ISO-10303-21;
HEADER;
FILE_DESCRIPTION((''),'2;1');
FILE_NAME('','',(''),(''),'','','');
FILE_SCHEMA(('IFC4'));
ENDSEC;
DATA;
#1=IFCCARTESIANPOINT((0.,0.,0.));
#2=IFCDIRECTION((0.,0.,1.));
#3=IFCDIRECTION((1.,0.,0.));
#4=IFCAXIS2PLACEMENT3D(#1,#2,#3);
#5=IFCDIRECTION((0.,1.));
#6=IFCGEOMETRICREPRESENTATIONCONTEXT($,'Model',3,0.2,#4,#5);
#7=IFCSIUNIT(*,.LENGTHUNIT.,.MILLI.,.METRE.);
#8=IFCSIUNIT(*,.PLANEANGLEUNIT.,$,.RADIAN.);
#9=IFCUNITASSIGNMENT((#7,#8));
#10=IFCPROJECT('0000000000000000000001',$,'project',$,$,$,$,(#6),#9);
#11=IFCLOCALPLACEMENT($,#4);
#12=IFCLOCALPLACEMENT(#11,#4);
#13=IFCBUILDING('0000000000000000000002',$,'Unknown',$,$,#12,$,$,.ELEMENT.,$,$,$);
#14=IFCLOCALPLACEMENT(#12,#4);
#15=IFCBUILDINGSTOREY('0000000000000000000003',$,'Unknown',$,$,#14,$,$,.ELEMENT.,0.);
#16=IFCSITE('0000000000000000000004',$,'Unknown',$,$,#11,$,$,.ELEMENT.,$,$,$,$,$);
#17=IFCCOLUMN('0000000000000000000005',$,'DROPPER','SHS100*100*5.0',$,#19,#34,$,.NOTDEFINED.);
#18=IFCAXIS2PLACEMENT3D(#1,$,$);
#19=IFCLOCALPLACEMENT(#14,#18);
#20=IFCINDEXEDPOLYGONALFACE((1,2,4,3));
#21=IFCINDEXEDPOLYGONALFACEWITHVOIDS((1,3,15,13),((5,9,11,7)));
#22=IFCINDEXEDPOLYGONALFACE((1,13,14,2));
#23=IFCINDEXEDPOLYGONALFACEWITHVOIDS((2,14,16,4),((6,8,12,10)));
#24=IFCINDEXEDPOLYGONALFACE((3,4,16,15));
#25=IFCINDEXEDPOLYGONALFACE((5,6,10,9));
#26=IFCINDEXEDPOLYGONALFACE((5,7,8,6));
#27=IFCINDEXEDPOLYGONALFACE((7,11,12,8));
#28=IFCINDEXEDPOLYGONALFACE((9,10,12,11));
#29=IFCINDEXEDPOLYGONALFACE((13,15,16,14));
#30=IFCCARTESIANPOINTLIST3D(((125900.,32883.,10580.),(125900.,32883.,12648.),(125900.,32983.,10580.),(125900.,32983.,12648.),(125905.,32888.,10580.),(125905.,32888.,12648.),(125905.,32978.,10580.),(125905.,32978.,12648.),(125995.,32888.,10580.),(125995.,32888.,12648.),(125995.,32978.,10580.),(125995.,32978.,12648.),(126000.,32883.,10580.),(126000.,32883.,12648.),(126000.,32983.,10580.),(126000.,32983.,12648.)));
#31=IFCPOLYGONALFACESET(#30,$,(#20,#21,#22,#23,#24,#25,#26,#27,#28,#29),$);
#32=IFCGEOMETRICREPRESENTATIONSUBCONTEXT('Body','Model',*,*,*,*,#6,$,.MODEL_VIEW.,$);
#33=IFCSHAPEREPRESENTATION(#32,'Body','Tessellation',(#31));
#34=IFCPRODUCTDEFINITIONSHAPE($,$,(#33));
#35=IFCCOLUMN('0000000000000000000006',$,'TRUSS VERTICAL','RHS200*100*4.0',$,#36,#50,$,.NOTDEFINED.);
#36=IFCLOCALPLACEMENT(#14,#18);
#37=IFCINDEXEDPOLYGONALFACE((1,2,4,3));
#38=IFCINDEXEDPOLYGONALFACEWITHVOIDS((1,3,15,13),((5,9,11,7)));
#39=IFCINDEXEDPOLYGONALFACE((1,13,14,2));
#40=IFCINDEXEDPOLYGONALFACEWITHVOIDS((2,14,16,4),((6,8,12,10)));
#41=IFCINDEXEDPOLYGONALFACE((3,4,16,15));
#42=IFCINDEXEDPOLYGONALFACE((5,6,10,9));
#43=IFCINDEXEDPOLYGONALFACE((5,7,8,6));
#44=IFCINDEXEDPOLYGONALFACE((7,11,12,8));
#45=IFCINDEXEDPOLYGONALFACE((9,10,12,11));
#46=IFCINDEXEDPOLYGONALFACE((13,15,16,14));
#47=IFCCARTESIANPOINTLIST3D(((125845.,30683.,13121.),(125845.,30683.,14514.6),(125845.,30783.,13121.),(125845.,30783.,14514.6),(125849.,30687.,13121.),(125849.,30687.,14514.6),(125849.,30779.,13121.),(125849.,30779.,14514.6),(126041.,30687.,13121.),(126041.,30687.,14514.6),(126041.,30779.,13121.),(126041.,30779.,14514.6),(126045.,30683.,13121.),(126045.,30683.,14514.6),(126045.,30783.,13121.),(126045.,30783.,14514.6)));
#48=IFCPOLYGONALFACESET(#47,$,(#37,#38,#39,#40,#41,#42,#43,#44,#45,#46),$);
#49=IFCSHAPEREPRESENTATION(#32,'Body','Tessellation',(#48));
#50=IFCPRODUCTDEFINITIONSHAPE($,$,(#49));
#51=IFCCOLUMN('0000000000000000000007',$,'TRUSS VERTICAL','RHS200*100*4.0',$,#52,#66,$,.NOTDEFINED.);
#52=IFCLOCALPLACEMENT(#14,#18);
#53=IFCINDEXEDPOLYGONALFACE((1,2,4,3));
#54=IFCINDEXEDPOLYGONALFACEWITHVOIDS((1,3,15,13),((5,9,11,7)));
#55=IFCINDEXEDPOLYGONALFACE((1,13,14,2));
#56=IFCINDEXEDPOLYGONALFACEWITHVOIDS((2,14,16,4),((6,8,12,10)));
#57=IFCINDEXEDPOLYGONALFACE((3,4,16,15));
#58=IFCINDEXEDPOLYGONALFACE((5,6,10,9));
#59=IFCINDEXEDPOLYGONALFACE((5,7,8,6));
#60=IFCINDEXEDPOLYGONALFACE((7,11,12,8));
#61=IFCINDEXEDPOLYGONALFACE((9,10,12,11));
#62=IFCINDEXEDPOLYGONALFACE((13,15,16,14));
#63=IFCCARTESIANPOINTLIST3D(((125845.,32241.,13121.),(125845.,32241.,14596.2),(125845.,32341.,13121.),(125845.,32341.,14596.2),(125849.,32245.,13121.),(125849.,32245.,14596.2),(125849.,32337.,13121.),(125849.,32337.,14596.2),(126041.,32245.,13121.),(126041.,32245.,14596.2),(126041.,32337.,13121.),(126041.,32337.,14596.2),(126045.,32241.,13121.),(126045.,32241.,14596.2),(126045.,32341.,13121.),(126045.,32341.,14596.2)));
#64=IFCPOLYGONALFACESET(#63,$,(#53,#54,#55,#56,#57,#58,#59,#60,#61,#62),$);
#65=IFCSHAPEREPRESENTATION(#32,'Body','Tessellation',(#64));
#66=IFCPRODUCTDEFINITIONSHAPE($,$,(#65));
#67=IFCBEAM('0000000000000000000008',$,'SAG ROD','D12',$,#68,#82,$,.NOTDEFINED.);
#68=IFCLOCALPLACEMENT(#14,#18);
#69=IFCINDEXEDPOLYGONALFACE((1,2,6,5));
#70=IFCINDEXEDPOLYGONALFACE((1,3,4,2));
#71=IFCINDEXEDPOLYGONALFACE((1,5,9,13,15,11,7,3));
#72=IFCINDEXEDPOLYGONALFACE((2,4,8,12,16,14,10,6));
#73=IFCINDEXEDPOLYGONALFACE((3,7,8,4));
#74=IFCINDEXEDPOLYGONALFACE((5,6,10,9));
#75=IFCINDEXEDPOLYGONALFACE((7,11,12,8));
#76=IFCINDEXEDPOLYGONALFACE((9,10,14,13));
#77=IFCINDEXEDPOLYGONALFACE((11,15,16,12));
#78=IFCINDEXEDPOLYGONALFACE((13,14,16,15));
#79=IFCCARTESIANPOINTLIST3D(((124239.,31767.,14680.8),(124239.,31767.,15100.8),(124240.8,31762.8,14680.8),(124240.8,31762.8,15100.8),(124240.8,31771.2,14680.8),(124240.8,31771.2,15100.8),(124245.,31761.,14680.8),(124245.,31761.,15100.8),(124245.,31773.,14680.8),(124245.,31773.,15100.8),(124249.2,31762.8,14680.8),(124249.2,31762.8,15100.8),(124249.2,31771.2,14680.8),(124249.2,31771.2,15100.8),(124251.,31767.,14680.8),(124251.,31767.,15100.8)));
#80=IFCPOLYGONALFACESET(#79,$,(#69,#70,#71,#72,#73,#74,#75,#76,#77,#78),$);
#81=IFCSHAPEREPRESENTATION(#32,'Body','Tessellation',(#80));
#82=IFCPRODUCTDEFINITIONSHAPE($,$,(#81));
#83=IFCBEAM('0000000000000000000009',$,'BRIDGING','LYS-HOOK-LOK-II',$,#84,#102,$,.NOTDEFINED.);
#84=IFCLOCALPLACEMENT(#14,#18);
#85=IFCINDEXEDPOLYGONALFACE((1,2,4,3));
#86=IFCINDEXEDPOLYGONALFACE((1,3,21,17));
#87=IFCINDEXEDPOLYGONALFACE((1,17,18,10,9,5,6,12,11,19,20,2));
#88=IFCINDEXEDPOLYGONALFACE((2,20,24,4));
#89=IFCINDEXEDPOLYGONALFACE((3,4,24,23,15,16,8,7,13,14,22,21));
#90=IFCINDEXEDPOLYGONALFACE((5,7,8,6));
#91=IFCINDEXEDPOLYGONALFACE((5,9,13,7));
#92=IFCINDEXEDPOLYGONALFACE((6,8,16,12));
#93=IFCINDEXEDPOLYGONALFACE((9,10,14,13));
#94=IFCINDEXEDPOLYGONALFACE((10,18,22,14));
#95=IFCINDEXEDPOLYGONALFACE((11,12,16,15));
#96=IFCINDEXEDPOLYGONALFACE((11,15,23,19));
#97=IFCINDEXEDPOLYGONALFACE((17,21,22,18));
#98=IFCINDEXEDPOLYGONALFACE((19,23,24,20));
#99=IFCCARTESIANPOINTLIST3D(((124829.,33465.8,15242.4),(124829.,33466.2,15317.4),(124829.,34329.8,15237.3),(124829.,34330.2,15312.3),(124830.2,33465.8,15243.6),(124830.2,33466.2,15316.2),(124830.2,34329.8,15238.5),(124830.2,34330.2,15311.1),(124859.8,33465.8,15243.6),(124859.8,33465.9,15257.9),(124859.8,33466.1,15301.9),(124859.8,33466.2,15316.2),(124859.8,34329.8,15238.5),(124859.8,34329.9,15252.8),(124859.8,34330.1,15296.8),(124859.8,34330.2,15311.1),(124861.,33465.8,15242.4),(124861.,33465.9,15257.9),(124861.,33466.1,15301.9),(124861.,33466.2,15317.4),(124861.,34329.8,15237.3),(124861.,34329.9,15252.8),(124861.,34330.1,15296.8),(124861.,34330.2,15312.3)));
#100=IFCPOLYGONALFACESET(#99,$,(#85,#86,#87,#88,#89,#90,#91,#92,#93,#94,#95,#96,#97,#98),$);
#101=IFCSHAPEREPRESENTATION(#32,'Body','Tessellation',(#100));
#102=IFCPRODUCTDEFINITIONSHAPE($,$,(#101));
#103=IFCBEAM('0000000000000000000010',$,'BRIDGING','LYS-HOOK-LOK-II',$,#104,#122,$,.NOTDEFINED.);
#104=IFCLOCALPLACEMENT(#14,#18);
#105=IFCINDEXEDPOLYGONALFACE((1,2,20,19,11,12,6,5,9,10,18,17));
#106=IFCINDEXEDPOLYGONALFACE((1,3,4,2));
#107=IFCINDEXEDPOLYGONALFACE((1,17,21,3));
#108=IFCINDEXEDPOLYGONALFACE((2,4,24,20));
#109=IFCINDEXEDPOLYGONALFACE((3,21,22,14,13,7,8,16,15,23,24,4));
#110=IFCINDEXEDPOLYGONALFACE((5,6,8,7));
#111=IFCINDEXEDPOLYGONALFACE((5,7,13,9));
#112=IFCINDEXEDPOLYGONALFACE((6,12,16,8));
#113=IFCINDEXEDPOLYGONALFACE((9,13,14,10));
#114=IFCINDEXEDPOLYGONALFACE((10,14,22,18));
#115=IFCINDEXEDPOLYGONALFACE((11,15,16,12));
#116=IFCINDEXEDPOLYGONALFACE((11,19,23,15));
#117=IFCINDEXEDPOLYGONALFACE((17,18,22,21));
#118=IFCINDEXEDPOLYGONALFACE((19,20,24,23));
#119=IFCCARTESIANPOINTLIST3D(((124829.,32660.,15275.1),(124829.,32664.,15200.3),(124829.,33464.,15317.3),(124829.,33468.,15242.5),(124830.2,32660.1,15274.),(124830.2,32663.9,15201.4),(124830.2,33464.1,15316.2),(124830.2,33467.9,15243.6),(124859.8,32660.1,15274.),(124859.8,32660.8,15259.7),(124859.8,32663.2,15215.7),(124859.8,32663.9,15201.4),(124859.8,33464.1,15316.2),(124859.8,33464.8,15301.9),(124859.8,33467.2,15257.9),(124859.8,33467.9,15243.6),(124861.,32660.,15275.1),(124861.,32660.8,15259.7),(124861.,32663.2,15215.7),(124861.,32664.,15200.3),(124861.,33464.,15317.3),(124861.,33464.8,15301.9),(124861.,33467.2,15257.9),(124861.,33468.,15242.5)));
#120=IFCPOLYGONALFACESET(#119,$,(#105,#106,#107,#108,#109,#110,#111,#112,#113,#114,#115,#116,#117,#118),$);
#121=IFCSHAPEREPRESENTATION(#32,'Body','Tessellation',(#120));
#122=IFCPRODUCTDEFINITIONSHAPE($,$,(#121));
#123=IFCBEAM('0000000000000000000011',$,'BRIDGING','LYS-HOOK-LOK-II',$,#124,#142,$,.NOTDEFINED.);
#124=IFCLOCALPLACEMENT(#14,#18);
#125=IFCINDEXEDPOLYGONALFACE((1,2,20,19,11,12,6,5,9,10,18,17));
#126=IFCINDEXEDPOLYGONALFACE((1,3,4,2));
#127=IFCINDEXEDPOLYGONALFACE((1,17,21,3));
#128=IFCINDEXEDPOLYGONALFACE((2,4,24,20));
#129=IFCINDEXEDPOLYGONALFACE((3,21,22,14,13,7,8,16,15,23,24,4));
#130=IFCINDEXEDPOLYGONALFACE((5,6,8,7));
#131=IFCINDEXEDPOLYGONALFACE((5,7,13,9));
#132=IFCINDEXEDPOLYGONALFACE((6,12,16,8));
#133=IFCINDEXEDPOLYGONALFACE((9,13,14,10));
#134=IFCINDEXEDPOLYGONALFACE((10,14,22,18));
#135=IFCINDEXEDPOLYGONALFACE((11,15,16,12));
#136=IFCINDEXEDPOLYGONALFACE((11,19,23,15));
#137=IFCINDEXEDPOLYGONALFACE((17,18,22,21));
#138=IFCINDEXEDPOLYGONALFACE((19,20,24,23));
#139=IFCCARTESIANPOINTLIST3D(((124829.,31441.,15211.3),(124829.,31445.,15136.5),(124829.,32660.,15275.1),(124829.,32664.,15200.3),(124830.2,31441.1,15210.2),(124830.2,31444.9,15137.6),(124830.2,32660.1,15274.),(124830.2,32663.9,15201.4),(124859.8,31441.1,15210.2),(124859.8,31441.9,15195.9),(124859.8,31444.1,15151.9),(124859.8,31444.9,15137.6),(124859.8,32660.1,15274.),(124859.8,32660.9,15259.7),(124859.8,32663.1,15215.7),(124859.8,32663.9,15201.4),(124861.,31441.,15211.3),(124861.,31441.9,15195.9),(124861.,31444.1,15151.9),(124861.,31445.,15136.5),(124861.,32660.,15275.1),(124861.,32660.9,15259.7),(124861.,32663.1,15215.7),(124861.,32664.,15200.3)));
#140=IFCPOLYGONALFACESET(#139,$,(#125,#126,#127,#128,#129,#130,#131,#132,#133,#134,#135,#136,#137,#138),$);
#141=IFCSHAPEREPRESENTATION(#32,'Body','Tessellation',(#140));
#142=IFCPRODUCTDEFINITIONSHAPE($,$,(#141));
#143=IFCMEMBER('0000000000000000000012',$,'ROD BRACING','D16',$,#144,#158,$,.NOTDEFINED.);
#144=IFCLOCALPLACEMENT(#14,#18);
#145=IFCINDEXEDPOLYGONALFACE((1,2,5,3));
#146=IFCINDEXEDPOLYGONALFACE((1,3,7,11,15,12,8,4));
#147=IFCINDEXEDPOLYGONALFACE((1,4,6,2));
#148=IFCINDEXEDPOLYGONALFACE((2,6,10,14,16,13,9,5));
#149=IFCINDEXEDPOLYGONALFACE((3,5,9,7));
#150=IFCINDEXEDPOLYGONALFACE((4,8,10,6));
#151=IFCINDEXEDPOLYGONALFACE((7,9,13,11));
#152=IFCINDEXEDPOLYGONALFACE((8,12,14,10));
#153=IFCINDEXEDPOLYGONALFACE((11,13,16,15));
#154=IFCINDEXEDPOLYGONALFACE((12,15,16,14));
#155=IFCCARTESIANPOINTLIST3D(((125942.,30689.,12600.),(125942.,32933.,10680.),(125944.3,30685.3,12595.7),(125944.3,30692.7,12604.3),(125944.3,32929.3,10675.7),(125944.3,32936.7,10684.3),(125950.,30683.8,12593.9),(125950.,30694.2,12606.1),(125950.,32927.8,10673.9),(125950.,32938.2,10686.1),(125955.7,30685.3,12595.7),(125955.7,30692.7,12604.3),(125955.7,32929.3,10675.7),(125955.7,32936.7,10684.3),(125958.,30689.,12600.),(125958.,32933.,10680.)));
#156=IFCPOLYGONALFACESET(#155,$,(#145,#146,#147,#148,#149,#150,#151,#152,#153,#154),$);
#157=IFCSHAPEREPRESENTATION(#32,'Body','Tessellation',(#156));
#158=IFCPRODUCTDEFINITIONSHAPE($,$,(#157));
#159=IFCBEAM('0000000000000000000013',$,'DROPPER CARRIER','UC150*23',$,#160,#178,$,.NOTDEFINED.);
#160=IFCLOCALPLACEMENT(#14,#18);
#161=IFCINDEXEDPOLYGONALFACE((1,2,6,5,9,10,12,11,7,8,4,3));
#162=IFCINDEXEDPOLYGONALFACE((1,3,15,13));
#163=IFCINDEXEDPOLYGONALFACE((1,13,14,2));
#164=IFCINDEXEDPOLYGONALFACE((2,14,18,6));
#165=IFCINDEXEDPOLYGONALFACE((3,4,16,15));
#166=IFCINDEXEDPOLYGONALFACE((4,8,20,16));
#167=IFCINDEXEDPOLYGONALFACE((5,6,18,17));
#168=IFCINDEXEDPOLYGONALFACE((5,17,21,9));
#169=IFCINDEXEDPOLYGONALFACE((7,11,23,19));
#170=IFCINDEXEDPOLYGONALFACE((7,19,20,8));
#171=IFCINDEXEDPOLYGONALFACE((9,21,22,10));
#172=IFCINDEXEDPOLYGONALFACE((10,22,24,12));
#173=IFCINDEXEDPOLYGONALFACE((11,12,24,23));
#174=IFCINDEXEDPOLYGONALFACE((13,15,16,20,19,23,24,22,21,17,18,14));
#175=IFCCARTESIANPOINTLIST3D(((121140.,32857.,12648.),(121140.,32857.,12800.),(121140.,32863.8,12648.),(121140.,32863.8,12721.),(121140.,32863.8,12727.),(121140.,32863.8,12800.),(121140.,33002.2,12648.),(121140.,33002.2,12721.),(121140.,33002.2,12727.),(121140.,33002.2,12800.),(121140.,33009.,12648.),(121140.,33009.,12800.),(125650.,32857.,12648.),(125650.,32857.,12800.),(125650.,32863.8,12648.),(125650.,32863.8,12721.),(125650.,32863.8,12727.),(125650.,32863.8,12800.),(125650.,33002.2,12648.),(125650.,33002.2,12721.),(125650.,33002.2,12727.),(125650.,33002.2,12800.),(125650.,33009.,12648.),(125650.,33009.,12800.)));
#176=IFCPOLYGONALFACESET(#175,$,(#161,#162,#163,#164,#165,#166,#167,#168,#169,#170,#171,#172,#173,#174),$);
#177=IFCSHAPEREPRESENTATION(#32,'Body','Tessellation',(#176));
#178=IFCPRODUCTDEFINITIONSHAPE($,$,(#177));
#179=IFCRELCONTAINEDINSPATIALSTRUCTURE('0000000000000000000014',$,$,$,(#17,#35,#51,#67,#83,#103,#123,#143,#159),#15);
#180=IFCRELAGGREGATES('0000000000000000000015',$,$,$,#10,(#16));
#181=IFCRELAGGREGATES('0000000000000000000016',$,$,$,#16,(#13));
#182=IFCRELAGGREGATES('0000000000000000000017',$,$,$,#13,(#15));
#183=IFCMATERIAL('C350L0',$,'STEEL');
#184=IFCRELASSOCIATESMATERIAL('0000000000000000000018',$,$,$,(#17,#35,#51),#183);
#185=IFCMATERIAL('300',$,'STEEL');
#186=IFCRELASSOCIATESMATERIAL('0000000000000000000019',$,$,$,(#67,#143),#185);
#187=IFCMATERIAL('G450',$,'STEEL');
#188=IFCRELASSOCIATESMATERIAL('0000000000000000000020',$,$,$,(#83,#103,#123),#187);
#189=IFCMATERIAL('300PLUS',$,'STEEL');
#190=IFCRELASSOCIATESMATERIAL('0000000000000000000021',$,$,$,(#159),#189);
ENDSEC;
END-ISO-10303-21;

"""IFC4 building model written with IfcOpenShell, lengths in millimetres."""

from ifc_helpers import new_model, si_unit, direction, frame, origin_with_axes, place, context, subcontext, project, spatial, line, indexed_curve, outline, extrude, material, element, save


model = new_model("IFC4")

# Units and contexts
model_context = context("Model", 3, precision=0.2, world=origin_with_axes(), true_north=direction((0.0, 1.0)))
body_context = subcontext(model_context, "Body", "Model", "MODEL_VIEW")
ifc_project = project(units=[si_unit("LENGTHUNIT", "METRE", prefix="MILLI"), si_unit("PLANEANGLEUNIT", "RADIAN")], contexts=[model_context])

# Site, building, storey
site_placement = place(None, origin_with_axes())
site = spatial("IfcSite", under=ifc_project, at=site_placement, Name="Unknown", CompositionType="ELEMENT")
building_placement = place(site_placement, origin_with_axes())
building = spatial("IfcBuilding", under=site, at=building_placement, Name="Unknown", CompositionType="ELEMENT")
storey_placement = place(building_placement, origin_with_axes())
storey = spatial("IfcBuildingStorey", under=building, at=storey_placement, Name="Unknown", CompositionType="ELEMENT", Elevation=0.0)

# Columns
ifc_material_1 = material(Name="C350L0", Category="STEEL")
column_1_placement = place(storey_placement, frame((125950.0, 32933.0, 10580.0), z_axis=(-1.0, 0.0, 0.0), x_axis=(0.0, 0.0, 1.0)))
element("IfcColumn", 1, at=column_1_placement, inside=storey, material=ifc_material_1, Name="DROPPER", Description="SHS100*100*5.0", PredefinedType="NOTDEFINED", context=body_context, shape_type="SolidModel", body=[
    extrude(outline(indexed_curve([(-50.0, -50.0), (50.0, -50.0), (50.0, 50.0), (-50.0, 50.0)], segments=[line(1, 2, 3, 4, 1)]), holes=[indexed_curve([(-45.0, -45.0), (-45.0, 45.0), (45.0, 45.0), (45.0, -45.0)], segments=[line(1, 2, 3, 4, 1)])]), frame((0.0, 0.0, 0.0), z_axis=(-1.0, 0.0, 0.0), x_axis=(0.0, 0.0, 1.0)), (0.0, 0.0, -1.0), 2068.0),
])
column_2_placement = place(storey_placement, frame((125945.0, 30733.0, 13121.0), z_axis=(0.0, -1.0, 0.0), x_axis=(0.0, 0.0, 1.0)))
element("IfcColumn", 2, at=column_2_placement, inside=storey, material=ifc_material_1, Name="TRUSS VERTICAL", Description="RHS200*100*4.0", PredefinedType="NOTDEFINED", context=body_context, shape_type="SolidModel", body=[
    extrude(outline(indexed_curve([(-50.0, -100.0), (50.0, -100.0), (50.0, 100.0), (-50.0, 100.0)], segments=[line(1, 2, 3, 4, 1)]), holes=[indexed_curve([(-46.0, -96.0), (-46.0, 96.0), (46.0, 96.0), (46.0, -96.0)], segments=[line(1, 2, 3, 4, 1)])]), frame((0.0, 0.0, 0.0), z_axis=(-1.0, 0.0, 0.0), x_axis=(0.0, 0.0, 1.0)), (0.0, 0.0, -1.0), 1393.6),
])
column_3_placement = place(storey_placement, frame((125945.0, 32291.0, 13121.0), z_axis=(0.0, -1.0, 0.0), x_axis=(0.0, 0.0, 1.0)))
element("IfcColumn", 3, at=column_3_placement, inside=storey, material=ifc_material_1, Name="TRUSS VERTICAL", Description="RHS200*100*4.0", PredefinedType="NOTDEFINED", context=body_context, shape_type="SolidModel", body=[
    extrude(outline(indexed_curve([(-50.0, -100.0), (50.0, -100.0), (50.0, 100.0), (-50.0, 100.0)], segments=[line(1, 2, 3, 4, 1)]), holes=[indexed_curve([(-46.0, -96.0), (-46.0, 96.0), (46.0, 96.0), (46.0, -96.0)], segments=[line(1, 2, 3, 4, 1)])]), frame((0.0, 0.0, 0.0), z_axis=(-1.0, 0.0, 0.0), x_axis=(0.0, 0.0, 1.0)), (0.0, 0.0, -1.0), 1475.2),
])

# Beams
ifc_material_2 = material(Name="300", Category="STEEL")
beam_1_placement = place(storey_placement, frame((124245.0, 31767.0, 15100.8), z_axis=(1.0, 0.0, 0.0), x_axis=(0.0, 0.0, -1.0)))
element("IfcBeam", 4, at=beam_1_placement, inside=storey, material=ifc_material_2, Name="SAG ROD", Description="D12", PredefinedType="NOTDEFINED", context=body_context, shape_type="SolidModel", body=[
    extrude(outline(indexed_curve([(6.0, 0.0), (4.2, 4.2), (0.0, 6.0), (-4.2, 4.2), (-6.0, 0.0), (-4.2, -4.2), (0.0, -6.0), (4.2, -4.2)], segments=[line(1, 2, 3, 4, 5, 6, 7, 8, 1)])), frame((0.0, 0.0, 0.0), z_axis=(-1.0, 0.0, 0.0), x_axis=(0.0, 0.0, 1.0)), (0.0, 0.0, -1.0), 420.0),
])
ifc_material_3 = material(Name="G450", Category="STEEL")
beam_2_placement = place(storey_placement, frame((124845.0, 33466.0, 15279.9), z_axis=(1.0, 0.0, 0.0), x_axis=(0.0, 0.999983, -0.005903)))
element("IfcBeam", 5, at=beam_2_placement, inside=storey, material=ifc_material_3, Name="BRIDGING", Description="LYS-HOOK-LOK-II", PredefinedType="NOTDEFINED", context=body_context, shape_type="SolidModel", body=[
    extrude(outline(indexed_curve([(16.0, -37.5), (16.0, -22.0), (14.8, -22.0), (14.8, -36.3), (-14.8, -36.3), (-14.8, 36.3), (14.8, 36.3), (14.8, 22.0), (16.0, 22.0), (16.0, 37.5), (-16.0, 37.5), (-16.0, -37.5)], segments=[line(1, 2, 3, 4, 5, 6, 7, 8, 9, 10, 11, 12, 1)])), frame((0.0, 0.0, 0.0), z_axis=(-1.0, 0.0, 0.0), x_axis=(0.0, 0.0, 1.0)), (0.0, 0.0, -1.0), 864.0),
])
beam_3_placement = place(storey_placement, frame((124845.0, 32662.0, 15237.7), z_axis=(1.0, 0.0, 0.0), x_axis=(0.0, 0.998625, 0.052415)))
element("IfcBeam", 6, at=beam_3_placement, inside=storey, material=ifc_material_3, Name="BRIDGING", Description="LYS-HOOK-LOK-II", PredefinedType="NOTDEFINED", context=body_context, shape_type="SolidModel", body=[
    extrude(outline(indexed_curve([(16.0, -37.5), (16.0, -22.0), (14.8, -22.0), (14.8, -36.3), (-14.8, -36.3), (-14.8, 36.3), (14.8, 36.3), (14.8, 22.0), (16.0, 22.0), (16.0, 37.5), (-16.0, 37.5), (-16.0, -37.5)], segments=[line(1, 2, 3, 4, 5, 6, 7, 8, 9, 10, 11, 12, 1)])), frame((0.0, 0.0, 0.0), z_axis=(-1.0, 0.0, 0.0), x_axis=(0.0, 0.0, 1.0)), (0.0, 0.0, -1.0), 805.1),
])
beam_4_placement = place(storey_placement, frame((124845.0, 31443.0, 15173.9), z_axis=(1.0, 0.0, 0.0), x_axis=(0.0, 0.998633, 0.052266)))
element("IfcBeam", 7, at=beam_4_placement, inside=storey, material=ifc_material_3, Name="BRIDGING", Description="LYS-HOOK-LOK-II", PredefinedType="NOTDEFINED", context=body_context, shape_type="SolidModel", body=[
    extrude(outline(indexed_curve([(16.0, -37.5), (16.0, -22.0), (14.8, -22.0), (14.8, -36.3), (-14.8, -36.3), (-14.8, 36.3), (14.8, 36.3), (14.8, 22.0), (16.0, 22.0), (16.0, 37.5), (-16.0, 37.5), (-16.0, -37.5)], segments=[line(1, 2, 3, 4, 5, 6, 7, 8, 9, 10, 11, 12, 1)])), frame((0.0, 0.0, 0.0), z_axis=(-1.0, 0.0, 0.0), x_axis=(0.0, 0.0, 1.0)), (0.0, 0.0, -1.0), 1220.7),
])

# Member
member_placement = place(storey_placement, frame((125950.0, 32933.0, 10680.0), z_axis=(0.0, 0.650122, 0.75983), x_axis=(0.0, -0.75983, 0.650122)))
element("IfcMember", 8, at=member_placement, inside=storey, material=ifc_material_2, Name="ROD BRACING", Description="D16", PredefinedType="NOTDEFINED", context=body_context, shape_type="SolidModel", body=[
    extrude(outline(indexed_curve([(8.0, 0.0), (5.7, 5.7), (0.0, 8.0), (-5.7, 5.7), (-8.0, 0.0), (-5.7, -5.7), (0.0, -8.0), (5.7, -5.7)], segments=[line(1, 2, 3, 4, 5, 6, 7, 8, 1)])), frame((0.0, 0.0, 0.0), z_axis=(-1.0, 0.0, 0.0), x_axis=(0.0, 0.0, 1.0)), (0.0, 0.0, -1.0), 2953.3),
])

# Beam
ifc_material_4 = material(Name="300PLUS", Category="STEEL")
beam_5_placement = place(storey_placement, frame((121140.0, 32933.0, 12724.0), z_axis=(0.0, 0.0, 1.0), x_axis=(1.0, 0.0, 0.0)))
element("IfcBeam", 9, at=beam_5_placement, inside=storey, material=ifc_material_4, Name="DROPPER CARRIER", Description="UC150*23", PredefinedType="NOTDEFINED", context=body_context, shape_type="SolidModel", body=[
    extrude(outline(indexed_curve([(-76.0, -76.0), (76.0, -76.0), (76.0, -69.2), (3.0, -69.2), (3.0, 69.2), (76.0, 69.2), (76.0, 76.0), (-76.0, 76.0), (-76.0, 69.2), (-3.0, 69.2), (-3.0, -69.2), (-76.0, -69.2)], segments=[line(1, 2, 3, 4, 5, 6, 7, 8, 9, 10, 11, 12, 1)])), frame((0.0, 0.0, 0.0), z_axis=(-1.0, 0.0, 0.0), x_axis=(0.0, 0.0, 1.0)), (0.0, 0.0, -1.0), 4510.0),
])

save(model, "model.ifc")
